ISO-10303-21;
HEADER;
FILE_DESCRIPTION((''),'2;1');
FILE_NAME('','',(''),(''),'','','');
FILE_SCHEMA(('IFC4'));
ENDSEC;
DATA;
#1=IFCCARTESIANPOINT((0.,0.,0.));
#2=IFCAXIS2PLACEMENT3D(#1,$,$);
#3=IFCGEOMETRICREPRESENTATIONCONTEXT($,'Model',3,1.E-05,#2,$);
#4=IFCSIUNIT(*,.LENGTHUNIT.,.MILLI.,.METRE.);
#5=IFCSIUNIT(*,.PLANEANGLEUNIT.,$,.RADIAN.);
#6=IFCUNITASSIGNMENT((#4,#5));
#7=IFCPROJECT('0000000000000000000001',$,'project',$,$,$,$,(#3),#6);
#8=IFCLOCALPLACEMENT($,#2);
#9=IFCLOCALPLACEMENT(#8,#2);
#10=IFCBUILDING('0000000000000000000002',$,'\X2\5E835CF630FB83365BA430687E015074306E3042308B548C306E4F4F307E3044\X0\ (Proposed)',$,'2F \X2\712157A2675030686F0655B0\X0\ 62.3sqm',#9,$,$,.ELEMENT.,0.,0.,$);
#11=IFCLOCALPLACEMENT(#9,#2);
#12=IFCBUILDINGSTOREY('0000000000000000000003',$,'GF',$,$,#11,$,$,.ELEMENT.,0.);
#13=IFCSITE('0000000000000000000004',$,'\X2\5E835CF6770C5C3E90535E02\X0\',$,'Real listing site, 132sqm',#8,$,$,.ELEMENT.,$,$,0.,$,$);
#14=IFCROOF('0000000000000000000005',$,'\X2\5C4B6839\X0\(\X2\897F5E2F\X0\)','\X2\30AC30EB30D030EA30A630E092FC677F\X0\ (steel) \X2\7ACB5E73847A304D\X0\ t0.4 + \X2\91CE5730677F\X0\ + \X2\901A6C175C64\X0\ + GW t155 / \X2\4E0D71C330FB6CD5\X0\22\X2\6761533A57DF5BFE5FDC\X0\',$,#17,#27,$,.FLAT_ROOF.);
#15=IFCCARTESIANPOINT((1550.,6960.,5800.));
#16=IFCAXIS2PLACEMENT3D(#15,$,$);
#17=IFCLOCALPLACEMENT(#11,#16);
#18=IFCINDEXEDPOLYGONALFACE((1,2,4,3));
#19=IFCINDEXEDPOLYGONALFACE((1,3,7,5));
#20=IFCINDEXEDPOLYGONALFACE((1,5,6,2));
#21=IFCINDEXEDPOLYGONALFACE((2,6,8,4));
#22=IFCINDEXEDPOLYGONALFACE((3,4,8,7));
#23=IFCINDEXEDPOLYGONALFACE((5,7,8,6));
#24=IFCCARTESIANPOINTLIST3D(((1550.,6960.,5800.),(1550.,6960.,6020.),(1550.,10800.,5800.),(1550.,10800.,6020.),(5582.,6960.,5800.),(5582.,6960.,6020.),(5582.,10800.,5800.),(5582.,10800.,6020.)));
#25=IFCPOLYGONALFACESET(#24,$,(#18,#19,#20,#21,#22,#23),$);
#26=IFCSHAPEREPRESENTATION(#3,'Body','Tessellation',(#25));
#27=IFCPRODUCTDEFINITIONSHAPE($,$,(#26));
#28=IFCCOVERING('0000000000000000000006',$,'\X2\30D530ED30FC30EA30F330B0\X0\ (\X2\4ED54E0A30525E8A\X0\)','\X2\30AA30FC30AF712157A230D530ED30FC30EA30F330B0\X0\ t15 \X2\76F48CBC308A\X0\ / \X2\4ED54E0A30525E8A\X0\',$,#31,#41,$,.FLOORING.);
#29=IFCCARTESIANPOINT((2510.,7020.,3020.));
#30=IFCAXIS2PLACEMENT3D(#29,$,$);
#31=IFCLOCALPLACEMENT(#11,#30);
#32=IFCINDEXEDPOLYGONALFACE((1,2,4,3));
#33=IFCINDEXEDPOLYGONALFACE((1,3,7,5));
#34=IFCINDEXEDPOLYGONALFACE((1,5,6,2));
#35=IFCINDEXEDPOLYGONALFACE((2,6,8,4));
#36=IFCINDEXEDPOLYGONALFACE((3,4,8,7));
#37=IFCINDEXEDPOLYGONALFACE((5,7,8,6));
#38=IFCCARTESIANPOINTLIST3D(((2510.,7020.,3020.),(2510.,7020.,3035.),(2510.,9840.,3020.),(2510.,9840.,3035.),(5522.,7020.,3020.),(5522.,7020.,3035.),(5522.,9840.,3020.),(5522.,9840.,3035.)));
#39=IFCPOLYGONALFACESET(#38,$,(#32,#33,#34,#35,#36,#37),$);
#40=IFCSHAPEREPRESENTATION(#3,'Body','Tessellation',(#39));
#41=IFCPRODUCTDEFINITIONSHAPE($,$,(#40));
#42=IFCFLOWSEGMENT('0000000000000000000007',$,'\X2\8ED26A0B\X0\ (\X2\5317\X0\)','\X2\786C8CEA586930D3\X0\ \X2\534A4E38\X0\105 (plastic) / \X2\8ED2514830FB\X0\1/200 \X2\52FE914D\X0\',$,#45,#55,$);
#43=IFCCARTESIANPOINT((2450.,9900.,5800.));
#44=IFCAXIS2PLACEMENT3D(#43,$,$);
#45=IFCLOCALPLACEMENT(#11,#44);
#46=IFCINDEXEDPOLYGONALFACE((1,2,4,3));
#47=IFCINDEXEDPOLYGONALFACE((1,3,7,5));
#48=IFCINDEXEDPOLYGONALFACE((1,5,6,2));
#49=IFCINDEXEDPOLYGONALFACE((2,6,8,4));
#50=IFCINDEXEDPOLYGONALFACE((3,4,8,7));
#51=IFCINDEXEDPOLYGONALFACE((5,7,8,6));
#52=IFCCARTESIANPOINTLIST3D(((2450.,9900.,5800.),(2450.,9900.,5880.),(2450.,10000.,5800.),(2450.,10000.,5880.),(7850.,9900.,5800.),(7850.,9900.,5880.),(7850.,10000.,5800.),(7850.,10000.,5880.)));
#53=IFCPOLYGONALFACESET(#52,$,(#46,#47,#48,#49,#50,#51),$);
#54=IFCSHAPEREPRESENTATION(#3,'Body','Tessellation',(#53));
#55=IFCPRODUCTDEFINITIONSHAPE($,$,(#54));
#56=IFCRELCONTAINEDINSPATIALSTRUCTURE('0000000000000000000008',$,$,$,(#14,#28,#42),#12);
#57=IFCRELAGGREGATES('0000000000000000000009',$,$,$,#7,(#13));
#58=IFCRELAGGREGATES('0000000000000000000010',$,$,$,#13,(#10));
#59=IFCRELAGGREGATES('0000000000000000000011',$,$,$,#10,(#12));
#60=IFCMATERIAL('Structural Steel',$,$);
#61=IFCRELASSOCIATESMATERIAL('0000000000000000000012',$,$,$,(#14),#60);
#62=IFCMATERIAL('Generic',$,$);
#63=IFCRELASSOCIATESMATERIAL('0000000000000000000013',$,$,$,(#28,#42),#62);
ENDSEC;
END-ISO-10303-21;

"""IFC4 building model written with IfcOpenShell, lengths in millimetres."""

from ifc_helpers import new_model, si_unit, frame, frame_2d, origin, place, context, project, spatial, rectangle, extrude, material, element, save


model = new_model("IFC4")

# Units and contexts
model_context = context("Model", 3, precision=1e-05, world=origin())
ifc_project = project(units=[si_unit("LENGTHUNIT", "METRE", prefix="MILLI"), si_unit("PLANEANGLEUNIT", "RADIAN")], contexts=[model_context])

# Site, building, storey
site_placement = place(None, origin())
site = spatial("IfcSite", under=ifc_project, at=site_placement, Name="広島県尾道市", ObjectType="Real listing site, 132sqm", CompositionType="ELEMENT", RefElevation=0.0)
building_placement = place(site_placement, origin())
building = spatial("IfcBuilding", under=site, at=building_placement, Name="広島・茶室と縁側のある和の住まい (Proposed)", ObjectType="2F 無垢材と漆喰 62.3sqm", CompositionType="ELEMENT", ElevationOfRefHeight=0.0, ElevationOfTerrain=0.0)
storey_placement = place(building_placement, origin())
storey = spatial("IfcBuildingStorey", under=building, at=storey_placement, Name="GF", CompositionType="ELEMENT", Elevation=0.0)

# Roof
ifc_material_1 = material(Name="Structural Steel")
for number, where, name in (
    (1, (1550.0, 6960.0, 5800.0), "屋根(西帯)"),
):
    element("IfcRoof", number, at=place(storey_placement, frame(where)), inside=storey, material=ifc_material_1, Name=name, Description="ガルバリウム鋼板 (steel) 立平葺き t0.4 + 野地板 + 通気層 + GW t155 / 不燃・法22条区域対応", PredefinedType="FLAT_ROOF", context=model_context, shape_type="SweptSolid", body=[
        extrude(rectangle(XDim=4032.0, YDim=3840.0, at=frame_2d((2016.0, 1920.0))), frame((1550.0, 6960.0, 5800.0)), (0.0, 0.0, 1.0), 220.0),
    ])

# Covering
ifc_material_2 = material(Name="Generic")
covering_placement = place(storey_placement, frame((2510.0, 7020.0, 3020.0)))
element("IfcCovering", 2, at=covering_placement, inside=storey, material=ifc_material_2, Name="フローリング (仕上げ床)", Description="オーク無垢フローリング t15 直貼り / 仕上げ床", PredefinedType="FLOORING", context=model_context, shape_type="SweptSolid", body=[
    extrude(rectangle(XDim=3012.0, YDim=2820.0, at=frame_2d((1506.0, 1410.0))), frame((2510.0, 7020.0, 3020.0)), (0.0, 0.0, 1.0), 15.0),
])

# Flow segment
flow_segment_placement = place(storey_placement, frame((2450.0, 9900.0, 5800.0)))
element("IfcFlowSegment", 3, at=flow_segment_placement, inside=storey, material=ifc_material_2, Name="軒樋 (北)", Description="硬質塩ビ 半丸105 (plastic) / 軒先・1/200 勾配", context=model_context, shape_type="SweptSolid", body=[
    extrude(rectangle(XDim=5400.0, YDim=100.0, at=frame_2d((2700.0, 50.0))), frame((2450.0, 9900.0, 5800.0)), (0.0, 0.0, 1.0), 80.0),
])

save(model, "model.ifc")
